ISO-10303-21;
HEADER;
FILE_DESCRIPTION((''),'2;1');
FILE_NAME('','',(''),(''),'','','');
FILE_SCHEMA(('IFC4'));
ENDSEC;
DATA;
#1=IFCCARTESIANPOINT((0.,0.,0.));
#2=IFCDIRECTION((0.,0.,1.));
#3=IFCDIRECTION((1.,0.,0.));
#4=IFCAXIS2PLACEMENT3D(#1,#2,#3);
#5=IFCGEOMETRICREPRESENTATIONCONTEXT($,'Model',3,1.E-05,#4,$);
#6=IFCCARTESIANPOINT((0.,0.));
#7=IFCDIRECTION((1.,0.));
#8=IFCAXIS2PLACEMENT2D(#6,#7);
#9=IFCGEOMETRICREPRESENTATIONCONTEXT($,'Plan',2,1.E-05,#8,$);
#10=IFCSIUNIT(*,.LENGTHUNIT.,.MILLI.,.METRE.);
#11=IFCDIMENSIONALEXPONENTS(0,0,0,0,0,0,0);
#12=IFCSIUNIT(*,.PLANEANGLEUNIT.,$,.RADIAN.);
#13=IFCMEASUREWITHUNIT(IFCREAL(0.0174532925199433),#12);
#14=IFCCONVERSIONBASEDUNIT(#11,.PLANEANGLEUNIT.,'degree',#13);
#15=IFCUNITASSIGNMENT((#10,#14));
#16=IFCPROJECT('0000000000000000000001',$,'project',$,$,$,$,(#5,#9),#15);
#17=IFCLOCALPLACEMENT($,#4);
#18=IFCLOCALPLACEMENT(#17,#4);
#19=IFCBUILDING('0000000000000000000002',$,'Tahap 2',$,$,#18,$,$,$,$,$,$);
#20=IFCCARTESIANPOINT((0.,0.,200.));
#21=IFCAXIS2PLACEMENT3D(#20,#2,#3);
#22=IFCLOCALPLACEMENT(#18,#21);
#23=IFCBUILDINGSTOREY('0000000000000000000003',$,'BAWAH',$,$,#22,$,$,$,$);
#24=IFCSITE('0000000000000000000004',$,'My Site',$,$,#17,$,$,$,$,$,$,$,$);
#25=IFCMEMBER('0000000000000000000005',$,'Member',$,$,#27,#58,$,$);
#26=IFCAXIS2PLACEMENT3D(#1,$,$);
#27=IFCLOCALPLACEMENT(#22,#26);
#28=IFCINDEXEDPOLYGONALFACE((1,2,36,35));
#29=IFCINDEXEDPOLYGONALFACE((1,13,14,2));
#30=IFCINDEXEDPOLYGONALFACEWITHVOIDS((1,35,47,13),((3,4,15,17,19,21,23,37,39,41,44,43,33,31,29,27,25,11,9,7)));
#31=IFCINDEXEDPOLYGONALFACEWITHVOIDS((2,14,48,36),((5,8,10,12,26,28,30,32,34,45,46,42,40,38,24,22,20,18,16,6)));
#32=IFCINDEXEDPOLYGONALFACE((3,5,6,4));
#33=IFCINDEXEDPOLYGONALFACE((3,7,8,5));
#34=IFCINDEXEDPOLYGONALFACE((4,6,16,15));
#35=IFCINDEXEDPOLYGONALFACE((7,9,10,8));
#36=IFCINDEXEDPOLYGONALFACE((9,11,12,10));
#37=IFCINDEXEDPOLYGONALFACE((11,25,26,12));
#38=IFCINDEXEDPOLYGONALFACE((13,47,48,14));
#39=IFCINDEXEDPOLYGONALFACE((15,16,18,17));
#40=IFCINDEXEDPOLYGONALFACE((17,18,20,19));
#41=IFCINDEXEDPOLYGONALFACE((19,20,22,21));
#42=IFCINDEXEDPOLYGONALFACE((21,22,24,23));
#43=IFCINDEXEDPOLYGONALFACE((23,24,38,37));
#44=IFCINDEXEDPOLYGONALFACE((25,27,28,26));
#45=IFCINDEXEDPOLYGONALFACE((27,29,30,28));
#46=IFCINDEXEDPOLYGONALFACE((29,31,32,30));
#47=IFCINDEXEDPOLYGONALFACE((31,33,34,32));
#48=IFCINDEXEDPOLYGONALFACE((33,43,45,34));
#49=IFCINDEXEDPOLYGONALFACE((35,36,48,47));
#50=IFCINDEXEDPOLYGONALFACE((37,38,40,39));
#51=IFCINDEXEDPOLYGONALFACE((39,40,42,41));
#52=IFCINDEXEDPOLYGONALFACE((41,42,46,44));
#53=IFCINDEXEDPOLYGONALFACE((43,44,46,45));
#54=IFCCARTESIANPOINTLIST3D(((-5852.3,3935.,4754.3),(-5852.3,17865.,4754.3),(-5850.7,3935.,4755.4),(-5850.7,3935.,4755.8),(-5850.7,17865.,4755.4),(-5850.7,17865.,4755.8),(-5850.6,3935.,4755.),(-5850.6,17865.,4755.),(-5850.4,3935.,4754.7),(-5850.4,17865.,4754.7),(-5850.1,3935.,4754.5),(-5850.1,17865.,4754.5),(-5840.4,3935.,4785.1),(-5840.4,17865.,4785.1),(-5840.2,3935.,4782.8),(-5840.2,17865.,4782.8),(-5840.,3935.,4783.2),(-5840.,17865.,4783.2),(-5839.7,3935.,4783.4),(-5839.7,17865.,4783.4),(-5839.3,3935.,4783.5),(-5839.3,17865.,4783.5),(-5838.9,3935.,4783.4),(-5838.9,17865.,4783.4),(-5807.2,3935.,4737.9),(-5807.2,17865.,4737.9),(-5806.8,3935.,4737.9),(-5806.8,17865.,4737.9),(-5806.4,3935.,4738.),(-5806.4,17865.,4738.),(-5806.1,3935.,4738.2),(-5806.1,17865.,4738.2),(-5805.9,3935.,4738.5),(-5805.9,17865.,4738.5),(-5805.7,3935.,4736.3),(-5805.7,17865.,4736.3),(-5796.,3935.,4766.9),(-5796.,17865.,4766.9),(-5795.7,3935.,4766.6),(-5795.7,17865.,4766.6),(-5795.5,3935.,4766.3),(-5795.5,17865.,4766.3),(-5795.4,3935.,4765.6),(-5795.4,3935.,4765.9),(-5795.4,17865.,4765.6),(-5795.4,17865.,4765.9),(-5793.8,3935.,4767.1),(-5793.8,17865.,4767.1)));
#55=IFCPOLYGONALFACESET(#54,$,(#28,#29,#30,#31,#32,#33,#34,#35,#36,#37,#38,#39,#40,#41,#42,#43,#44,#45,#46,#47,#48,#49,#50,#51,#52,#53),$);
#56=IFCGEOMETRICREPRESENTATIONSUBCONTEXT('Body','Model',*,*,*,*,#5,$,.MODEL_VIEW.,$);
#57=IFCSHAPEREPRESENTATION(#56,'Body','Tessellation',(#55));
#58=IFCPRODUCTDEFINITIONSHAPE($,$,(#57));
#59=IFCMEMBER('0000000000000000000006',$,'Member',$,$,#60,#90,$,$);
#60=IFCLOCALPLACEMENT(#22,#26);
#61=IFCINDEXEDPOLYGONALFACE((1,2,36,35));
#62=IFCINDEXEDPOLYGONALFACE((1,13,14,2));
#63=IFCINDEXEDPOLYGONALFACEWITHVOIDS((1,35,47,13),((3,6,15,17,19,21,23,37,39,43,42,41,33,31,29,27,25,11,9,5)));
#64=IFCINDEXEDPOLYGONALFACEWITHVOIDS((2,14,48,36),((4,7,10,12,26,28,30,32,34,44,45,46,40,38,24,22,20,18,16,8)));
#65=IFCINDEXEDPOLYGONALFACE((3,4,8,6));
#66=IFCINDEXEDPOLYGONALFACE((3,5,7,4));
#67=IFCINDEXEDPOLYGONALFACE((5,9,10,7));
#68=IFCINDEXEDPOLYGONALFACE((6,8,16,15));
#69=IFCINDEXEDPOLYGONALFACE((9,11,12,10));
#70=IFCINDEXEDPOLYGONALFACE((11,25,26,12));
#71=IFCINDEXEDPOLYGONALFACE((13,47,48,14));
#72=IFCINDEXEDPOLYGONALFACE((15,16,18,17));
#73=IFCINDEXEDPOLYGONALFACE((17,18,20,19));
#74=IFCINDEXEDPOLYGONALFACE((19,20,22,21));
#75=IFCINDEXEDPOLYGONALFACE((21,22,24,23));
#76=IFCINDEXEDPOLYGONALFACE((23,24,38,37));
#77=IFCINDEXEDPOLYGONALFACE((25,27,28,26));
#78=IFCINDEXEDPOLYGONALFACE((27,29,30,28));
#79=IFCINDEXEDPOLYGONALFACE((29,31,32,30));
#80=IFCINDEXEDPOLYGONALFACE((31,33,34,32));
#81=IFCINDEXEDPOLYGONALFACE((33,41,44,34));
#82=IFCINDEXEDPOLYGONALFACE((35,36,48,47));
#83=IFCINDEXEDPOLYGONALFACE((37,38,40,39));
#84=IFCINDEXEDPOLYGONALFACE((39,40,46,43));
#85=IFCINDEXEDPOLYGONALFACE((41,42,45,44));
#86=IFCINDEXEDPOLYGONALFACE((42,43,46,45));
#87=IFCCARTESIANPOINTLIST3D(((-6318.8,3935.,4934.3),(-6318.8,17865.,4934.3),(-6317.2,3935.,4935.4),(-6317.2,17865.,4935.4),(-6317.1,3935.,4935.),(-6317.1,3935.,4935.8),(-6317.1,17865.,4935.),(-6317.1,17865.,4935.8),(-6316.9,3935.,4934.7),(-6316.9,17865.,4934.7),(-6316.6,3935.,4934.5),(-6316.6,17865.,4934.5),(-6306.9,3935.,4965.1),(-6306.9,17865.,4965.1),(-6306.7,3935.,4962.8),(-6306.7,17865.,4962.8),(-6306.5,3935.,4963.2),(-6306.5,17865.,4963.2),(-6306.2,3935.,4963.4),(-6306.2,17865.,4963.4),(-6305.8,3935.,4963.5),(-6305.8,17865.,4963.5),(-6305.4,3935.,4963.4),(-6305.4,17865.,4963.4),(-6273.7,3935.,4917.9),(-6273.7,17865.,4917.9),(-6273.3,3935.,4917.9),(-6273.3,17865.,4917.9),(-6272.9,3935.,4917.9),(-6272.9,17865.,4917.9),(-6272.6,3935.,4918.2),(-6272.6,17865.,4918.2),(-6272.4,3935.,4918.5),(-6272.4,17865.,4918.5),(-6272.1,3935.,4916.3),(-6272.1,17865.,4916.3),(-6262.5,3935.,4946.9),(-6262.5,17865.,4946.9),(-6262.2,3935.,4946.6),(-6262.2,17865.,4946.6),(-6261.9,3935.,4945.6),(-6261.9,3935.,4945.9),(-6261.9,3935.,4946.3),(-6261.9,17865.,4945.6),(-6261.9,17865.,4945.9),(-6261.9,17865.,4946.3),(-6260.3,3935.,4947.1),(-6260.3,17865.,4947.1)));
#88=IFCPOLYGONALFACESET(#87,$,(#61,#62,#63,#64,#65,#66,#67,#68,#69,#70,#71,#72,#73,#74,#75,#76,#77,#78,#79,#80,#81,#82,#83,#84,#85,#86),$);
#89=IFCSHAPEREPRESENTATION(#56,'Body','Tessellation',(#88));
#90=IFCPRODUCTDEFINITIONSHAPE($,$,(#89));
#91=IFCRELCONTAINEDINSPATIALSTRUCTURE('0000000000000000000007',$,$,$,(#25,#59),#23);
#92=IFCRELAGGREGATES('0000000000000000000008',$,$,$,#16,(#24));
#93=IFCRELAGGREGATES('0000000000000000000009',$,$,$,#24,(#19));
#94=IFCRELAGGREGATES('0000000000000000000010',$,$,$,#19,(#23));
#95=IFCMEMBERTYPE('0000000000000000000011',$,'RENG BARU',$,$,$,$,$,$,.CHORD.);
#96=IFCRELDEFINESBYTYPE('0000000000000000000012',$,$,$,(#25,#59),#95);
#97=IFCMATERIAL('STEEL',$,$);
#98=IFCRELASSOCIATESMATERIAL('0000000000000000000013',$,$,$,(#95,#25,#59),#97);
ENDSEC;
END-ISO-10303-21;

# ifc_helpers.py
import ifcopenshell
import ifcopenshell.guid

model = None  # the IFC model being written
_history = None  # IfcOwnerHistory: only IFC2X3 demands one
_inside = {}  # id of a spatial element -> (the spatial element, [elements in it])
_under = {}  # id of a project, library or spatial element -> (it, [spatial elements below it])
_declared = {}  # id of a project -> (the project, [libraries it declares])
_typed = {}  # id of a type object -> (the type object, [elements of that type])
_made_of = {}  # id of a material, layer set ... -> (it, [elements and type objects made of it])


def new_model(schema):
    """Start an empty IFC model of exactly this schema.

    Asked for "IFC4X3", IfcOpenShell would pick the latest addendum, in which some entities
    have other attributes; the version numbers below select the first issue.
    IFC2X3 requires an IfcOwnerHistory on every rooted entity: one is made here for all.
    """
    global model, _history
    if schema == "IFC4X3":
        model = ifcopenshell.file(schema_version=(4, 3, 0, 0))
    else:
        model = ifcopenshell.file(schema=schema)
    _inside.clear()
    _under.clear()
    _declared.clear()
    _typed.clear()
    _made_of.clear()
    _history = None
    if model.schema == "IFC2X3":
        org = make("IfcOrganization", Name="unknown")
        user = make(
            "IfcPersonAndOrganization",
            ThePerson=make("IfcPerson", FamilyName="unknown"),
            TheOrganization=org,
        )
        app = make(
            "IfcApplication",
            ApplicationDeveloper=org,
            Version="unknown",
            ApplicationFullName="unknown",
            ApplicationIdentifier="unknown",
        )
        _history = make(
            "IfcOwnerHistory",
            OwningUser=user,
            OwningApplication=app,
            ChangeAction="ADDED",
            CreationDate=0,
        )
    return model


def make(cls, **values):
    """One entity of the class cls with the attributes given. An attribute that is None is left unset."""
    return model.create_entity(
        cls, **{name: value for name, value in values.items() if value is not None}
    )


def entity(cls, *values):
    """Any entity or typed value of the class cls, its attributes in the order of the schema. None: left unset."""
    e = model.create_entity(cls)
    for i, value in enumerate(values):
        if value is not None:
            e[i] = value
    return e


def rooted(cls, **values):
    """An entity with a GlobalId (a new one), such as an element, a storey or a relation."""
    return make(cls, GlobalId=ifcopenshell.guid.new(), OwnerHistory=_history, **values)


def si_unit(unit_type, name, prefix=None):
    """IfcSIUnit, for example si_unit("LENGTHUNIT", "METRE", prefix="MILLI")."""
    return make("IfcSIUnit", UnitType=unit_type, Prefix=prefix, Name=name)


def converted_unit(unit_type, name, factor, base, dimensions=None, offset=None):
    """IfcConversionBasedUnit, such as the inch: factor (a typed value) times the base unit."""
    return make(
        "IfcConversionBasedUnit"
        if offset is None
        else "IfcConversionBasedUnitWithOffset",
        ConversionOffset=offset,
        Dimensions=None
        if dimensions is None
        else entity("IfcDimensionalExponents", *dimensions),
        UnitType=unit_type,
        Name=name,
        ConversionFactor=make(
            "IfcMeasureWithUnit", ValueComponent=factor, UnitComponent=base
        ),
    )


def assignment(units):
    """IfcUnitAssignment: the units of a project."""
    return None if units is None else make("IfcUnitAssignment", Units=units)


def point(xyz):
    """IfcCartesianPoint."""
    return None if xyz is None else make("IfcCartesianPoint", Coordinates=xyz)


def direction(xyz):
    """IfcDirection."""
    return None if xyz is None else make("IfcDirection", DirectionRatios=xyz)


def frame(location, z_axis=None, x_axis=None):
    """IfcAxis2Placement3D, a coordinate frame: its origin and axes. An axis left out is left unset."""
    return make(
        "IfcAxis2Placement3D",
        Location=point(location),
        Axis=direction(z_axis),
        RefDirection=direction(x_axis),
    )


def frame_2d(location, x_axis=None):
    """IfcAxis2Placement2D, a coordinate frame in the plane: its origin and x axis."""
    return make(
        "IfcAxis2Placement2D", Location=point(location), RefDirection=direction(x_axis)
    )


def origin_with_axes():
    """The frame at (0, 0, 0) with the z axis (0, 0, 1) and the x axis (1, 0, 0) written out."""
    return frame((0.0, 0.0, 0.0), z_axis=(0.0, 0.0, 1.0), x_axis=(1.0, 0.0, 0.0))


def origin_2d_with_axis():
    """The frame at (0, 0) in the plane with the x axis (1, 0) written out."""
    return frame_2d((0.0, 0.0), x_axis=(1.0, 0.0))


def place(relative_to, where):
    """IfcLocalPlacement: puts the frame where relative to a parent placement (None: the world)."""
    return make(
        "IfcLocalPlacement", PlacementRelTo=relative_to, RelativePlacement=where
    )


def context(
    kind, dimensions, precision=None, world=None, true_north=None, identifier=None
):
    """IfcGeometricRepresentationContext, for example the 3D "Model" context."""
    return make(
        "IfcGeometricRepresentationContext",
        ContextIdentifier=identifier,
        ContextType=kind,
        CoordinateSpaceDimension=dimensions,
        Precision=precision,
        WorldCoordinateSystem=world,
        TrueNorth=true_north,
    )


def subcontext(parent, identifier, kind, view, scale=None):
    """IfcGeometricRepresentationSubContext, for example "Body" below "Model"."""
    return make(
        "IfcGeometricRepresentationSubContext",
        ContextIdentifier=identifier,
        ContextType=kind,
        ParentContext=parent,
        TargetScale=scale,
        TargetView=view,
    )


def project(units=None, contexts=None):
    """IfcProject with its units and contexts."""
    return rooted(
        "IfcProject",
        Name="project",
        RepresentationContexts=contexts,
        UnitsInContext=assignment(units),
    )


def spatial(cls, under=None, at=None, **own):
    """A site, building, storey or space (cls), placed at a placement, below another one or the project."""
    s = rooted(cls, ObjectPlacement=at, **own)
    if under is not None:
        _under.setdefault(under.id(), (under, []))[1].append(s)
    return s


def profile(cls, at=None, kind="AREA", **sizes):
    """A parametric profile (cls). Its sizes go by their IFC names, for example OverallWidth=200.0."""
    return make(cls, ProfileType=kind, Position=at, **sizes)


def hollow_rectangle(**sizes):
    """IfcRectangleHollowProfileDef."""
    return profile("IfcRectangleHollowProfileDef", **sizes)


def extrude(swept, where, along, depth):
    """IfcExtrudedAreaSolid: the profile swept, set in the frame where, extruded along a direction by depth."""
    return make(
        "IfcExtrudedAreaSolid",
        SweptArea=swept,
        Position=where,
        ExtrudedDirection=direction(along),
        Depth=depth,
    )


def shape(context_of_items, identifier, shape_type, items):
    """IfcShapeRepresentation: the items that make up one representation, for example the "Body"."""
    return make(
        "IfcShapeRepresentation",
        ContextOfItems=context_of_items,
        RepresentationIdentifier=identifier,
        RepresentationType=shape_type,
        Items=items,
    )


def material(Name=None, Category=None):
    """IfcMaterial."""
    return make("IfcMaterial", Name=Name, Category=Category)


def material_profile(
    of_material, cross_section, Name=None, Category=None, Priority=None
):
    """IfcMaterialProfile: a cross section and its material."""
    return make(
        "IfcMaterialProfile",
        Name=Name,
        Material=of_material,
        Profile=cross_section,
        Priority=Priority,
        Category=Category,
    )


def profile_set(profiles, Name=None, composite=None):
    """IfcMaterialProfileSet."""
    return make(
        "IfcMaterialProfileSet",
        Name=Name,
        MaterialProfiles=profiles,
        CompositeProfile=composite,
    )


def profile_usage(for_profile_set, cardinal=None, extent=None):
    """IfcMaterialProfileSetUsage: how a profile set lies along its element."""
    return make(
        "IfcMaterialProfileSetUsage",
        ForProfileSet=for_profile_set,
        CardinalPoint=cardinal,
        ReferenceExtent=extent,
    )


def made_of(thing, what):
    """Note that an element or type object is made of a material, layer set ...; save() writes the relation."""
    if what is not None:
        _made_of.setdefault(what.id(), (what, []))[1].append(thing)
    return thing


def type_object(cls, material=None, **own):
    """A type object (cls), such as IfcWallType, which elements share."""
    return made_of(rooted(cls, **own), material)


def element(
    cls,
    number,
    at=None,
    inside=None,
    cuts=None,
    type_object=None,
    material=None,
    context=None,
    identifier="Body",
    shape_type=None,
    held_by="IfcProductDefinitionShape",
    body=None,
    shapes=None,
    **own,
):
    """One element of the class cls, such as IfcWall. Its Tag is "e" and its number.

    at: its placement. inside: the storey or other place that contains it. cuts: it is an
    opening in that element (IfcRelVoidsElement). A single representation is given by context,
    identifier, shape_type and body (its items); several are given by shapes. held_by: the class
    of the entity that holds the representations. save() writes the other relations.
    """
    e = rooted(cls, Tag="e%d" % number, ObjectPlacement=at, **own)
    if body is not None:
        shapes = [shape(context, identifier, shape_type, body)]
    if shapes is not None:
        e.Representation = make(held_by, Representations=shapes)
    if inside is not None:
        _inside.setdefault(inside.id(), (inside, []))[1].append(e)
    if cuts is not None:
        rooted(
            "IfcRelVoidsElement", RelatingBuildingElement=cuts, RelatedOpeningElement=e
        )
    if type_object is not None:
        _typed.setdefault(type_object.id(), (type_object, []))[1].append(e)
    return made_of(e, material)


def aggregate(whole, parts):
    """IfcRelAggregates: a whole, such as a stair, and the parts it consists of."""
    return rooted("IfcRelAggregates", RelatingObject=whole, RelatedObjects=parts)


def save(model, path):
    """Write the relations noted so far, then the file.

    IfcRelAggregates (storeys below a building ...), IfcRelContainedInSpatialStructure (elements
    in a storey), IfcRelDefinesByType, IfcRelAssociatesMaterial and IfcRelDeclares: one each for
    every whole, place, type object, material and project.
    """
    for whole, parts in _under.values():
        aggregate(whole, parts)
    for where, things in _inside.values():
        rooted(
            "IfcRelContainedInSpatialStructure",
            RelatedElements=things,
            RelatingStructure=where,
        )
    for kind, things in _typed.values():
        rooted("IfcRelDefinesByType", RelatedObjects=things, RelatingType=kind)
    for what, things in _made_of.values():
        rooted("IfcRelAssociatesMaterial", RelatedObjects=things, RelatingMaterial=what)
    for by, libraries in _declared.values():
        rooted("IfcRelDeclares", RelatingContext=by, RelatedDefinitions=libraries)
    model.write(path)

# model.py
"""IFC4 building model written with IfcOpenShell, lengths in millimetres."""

from ifc_helpers import new_model, entity, si_unit, converted_unit, frame, origin_with_axes, origin_2d_with_axis, place, context, subcontext, project, spatial, hollow_rectangle, extrude, material, material_profile, profile_set, profile_usage, type_object, element, save


model = new_model("IFC4")

# Units and contexts
model_context = context("Model", 3, precision=1e-05, world=origin_with_axes())
plan_context = context("Plan", 2, precision=1e-05, world=origin_2d_with_axis())
body_context = subcontext(model_context, "Body", "Model", "MODEL_VIEW")
ifc_project = project(units=[si_unit("LENGTHUNIT", "METRE", prefix="MILLI"), converted_unit("PLANEANGLEUNIT", "degree", entity("IfcReal", 0.0174532925199433), si_unit("PLANEANGLEUNIT", "RADIAN"), dimensions=[0, 0, 0, 0, 0, 0, 0])], contexts=[model_context, plan_context])

# Site, building, storey
site_placement = place(None, origin_with_axes())
site = spatial("IfcSite", under=ifc_project, at=site_placement, Name="My Site")
building_placement = place(site_placement, origin_with_axes())
building = spatial("IfcBuilding", under=site, at=building_placement, Name="Tahap 2")
storey_placement = place(building_placement, frame((0.0, 0.0, 200.0), z_axis=(0.0, 0.0, 1.0), x_axis=(1.0, 0.0, 0.0)))
storey = spatial("IfcBuildingStorey", under=building, at=storey_placement, Name="BAWAH")

# Shared definitions
ifc_material_1 = material(Name="STEEL")

# Members
ifc_material_profile_1 = material_profile(ifc_material_1, hollow_rectangle(XDim=50.0, YDim=33.0, WallThickness=1.0, InnerFilletRadius=1.0, OuterFilletRadius=0.0, kind="CURVE"))
ifc_profile_set_1 = profile_set([ifc_material_profile_1])
member_type_1 = type_object("IfcMemberType", Name="RENG BARU", PredefinedType="CHORD", material=ifc_profile_set_1)
ifc_profile_usage_1 = profile_usage(ifc_profile_set_1, cardinal=3)
member_1_placement = place(storey_placement, frame((-5805.7, 3935.0, 4736.3), z_axis=(0.0, 1.0, 0.0), x_axis=(-0.932954, 0.0, 0.359997)))
element("IfcMember", 1, at=member_1_placement, inside=storey, type_object=member_type_1, material=ifc_profile_usage_1, Name="Member", context=body_context, shape_type="SweptSolid", body=[
    extrude(hollow_rectangle(XDim=50.0, YDim=33.0, WallThickness=1.0, InnerFilletRadius=1.0, OuterFilletRadius=0.0, kind="CURVE"), frame((25.0, 16.5, 0.0), z_axis=(0.0, 0.0, 1.0), x_axis=(1.0, 0.0, 0.0)), (0.0, 0.0, 1.0), 13930.0),
])
ifc_profile_usage_2 = profile_usage(ifc_profile_set_1, cardinal=3)
member_2_placement = place(storey_placement, frame((-6272.1, 3935.0, 4916.3), z_axis=(0.0, 1.0, 0.0), x_axis=(-0.932954, 0.0, 0.359997)))
element("IfcMember", 2, at=member_2_placement, inside=storey, type_object=member_type_1, material=ifc_profile_usage_2, Name="Member", context=body_context, shape_type="SweptSolid", body=[
    extrude(hollow_rectangle(XDim=50.0, YDim=33.0, WallThickness=1.0, InnerFilletRadius=1.0, OuterFilletRadius=0.0, kind="CURVE"), frame((25.0, 16.5, 0.0), z_axis=(0.0, 0.0, 1.0), x_axis=(1.0, 0.0, 0.0)), (0.0, 0.0, 1.0), 13930.0),
])

save(model, "model.ifc")
